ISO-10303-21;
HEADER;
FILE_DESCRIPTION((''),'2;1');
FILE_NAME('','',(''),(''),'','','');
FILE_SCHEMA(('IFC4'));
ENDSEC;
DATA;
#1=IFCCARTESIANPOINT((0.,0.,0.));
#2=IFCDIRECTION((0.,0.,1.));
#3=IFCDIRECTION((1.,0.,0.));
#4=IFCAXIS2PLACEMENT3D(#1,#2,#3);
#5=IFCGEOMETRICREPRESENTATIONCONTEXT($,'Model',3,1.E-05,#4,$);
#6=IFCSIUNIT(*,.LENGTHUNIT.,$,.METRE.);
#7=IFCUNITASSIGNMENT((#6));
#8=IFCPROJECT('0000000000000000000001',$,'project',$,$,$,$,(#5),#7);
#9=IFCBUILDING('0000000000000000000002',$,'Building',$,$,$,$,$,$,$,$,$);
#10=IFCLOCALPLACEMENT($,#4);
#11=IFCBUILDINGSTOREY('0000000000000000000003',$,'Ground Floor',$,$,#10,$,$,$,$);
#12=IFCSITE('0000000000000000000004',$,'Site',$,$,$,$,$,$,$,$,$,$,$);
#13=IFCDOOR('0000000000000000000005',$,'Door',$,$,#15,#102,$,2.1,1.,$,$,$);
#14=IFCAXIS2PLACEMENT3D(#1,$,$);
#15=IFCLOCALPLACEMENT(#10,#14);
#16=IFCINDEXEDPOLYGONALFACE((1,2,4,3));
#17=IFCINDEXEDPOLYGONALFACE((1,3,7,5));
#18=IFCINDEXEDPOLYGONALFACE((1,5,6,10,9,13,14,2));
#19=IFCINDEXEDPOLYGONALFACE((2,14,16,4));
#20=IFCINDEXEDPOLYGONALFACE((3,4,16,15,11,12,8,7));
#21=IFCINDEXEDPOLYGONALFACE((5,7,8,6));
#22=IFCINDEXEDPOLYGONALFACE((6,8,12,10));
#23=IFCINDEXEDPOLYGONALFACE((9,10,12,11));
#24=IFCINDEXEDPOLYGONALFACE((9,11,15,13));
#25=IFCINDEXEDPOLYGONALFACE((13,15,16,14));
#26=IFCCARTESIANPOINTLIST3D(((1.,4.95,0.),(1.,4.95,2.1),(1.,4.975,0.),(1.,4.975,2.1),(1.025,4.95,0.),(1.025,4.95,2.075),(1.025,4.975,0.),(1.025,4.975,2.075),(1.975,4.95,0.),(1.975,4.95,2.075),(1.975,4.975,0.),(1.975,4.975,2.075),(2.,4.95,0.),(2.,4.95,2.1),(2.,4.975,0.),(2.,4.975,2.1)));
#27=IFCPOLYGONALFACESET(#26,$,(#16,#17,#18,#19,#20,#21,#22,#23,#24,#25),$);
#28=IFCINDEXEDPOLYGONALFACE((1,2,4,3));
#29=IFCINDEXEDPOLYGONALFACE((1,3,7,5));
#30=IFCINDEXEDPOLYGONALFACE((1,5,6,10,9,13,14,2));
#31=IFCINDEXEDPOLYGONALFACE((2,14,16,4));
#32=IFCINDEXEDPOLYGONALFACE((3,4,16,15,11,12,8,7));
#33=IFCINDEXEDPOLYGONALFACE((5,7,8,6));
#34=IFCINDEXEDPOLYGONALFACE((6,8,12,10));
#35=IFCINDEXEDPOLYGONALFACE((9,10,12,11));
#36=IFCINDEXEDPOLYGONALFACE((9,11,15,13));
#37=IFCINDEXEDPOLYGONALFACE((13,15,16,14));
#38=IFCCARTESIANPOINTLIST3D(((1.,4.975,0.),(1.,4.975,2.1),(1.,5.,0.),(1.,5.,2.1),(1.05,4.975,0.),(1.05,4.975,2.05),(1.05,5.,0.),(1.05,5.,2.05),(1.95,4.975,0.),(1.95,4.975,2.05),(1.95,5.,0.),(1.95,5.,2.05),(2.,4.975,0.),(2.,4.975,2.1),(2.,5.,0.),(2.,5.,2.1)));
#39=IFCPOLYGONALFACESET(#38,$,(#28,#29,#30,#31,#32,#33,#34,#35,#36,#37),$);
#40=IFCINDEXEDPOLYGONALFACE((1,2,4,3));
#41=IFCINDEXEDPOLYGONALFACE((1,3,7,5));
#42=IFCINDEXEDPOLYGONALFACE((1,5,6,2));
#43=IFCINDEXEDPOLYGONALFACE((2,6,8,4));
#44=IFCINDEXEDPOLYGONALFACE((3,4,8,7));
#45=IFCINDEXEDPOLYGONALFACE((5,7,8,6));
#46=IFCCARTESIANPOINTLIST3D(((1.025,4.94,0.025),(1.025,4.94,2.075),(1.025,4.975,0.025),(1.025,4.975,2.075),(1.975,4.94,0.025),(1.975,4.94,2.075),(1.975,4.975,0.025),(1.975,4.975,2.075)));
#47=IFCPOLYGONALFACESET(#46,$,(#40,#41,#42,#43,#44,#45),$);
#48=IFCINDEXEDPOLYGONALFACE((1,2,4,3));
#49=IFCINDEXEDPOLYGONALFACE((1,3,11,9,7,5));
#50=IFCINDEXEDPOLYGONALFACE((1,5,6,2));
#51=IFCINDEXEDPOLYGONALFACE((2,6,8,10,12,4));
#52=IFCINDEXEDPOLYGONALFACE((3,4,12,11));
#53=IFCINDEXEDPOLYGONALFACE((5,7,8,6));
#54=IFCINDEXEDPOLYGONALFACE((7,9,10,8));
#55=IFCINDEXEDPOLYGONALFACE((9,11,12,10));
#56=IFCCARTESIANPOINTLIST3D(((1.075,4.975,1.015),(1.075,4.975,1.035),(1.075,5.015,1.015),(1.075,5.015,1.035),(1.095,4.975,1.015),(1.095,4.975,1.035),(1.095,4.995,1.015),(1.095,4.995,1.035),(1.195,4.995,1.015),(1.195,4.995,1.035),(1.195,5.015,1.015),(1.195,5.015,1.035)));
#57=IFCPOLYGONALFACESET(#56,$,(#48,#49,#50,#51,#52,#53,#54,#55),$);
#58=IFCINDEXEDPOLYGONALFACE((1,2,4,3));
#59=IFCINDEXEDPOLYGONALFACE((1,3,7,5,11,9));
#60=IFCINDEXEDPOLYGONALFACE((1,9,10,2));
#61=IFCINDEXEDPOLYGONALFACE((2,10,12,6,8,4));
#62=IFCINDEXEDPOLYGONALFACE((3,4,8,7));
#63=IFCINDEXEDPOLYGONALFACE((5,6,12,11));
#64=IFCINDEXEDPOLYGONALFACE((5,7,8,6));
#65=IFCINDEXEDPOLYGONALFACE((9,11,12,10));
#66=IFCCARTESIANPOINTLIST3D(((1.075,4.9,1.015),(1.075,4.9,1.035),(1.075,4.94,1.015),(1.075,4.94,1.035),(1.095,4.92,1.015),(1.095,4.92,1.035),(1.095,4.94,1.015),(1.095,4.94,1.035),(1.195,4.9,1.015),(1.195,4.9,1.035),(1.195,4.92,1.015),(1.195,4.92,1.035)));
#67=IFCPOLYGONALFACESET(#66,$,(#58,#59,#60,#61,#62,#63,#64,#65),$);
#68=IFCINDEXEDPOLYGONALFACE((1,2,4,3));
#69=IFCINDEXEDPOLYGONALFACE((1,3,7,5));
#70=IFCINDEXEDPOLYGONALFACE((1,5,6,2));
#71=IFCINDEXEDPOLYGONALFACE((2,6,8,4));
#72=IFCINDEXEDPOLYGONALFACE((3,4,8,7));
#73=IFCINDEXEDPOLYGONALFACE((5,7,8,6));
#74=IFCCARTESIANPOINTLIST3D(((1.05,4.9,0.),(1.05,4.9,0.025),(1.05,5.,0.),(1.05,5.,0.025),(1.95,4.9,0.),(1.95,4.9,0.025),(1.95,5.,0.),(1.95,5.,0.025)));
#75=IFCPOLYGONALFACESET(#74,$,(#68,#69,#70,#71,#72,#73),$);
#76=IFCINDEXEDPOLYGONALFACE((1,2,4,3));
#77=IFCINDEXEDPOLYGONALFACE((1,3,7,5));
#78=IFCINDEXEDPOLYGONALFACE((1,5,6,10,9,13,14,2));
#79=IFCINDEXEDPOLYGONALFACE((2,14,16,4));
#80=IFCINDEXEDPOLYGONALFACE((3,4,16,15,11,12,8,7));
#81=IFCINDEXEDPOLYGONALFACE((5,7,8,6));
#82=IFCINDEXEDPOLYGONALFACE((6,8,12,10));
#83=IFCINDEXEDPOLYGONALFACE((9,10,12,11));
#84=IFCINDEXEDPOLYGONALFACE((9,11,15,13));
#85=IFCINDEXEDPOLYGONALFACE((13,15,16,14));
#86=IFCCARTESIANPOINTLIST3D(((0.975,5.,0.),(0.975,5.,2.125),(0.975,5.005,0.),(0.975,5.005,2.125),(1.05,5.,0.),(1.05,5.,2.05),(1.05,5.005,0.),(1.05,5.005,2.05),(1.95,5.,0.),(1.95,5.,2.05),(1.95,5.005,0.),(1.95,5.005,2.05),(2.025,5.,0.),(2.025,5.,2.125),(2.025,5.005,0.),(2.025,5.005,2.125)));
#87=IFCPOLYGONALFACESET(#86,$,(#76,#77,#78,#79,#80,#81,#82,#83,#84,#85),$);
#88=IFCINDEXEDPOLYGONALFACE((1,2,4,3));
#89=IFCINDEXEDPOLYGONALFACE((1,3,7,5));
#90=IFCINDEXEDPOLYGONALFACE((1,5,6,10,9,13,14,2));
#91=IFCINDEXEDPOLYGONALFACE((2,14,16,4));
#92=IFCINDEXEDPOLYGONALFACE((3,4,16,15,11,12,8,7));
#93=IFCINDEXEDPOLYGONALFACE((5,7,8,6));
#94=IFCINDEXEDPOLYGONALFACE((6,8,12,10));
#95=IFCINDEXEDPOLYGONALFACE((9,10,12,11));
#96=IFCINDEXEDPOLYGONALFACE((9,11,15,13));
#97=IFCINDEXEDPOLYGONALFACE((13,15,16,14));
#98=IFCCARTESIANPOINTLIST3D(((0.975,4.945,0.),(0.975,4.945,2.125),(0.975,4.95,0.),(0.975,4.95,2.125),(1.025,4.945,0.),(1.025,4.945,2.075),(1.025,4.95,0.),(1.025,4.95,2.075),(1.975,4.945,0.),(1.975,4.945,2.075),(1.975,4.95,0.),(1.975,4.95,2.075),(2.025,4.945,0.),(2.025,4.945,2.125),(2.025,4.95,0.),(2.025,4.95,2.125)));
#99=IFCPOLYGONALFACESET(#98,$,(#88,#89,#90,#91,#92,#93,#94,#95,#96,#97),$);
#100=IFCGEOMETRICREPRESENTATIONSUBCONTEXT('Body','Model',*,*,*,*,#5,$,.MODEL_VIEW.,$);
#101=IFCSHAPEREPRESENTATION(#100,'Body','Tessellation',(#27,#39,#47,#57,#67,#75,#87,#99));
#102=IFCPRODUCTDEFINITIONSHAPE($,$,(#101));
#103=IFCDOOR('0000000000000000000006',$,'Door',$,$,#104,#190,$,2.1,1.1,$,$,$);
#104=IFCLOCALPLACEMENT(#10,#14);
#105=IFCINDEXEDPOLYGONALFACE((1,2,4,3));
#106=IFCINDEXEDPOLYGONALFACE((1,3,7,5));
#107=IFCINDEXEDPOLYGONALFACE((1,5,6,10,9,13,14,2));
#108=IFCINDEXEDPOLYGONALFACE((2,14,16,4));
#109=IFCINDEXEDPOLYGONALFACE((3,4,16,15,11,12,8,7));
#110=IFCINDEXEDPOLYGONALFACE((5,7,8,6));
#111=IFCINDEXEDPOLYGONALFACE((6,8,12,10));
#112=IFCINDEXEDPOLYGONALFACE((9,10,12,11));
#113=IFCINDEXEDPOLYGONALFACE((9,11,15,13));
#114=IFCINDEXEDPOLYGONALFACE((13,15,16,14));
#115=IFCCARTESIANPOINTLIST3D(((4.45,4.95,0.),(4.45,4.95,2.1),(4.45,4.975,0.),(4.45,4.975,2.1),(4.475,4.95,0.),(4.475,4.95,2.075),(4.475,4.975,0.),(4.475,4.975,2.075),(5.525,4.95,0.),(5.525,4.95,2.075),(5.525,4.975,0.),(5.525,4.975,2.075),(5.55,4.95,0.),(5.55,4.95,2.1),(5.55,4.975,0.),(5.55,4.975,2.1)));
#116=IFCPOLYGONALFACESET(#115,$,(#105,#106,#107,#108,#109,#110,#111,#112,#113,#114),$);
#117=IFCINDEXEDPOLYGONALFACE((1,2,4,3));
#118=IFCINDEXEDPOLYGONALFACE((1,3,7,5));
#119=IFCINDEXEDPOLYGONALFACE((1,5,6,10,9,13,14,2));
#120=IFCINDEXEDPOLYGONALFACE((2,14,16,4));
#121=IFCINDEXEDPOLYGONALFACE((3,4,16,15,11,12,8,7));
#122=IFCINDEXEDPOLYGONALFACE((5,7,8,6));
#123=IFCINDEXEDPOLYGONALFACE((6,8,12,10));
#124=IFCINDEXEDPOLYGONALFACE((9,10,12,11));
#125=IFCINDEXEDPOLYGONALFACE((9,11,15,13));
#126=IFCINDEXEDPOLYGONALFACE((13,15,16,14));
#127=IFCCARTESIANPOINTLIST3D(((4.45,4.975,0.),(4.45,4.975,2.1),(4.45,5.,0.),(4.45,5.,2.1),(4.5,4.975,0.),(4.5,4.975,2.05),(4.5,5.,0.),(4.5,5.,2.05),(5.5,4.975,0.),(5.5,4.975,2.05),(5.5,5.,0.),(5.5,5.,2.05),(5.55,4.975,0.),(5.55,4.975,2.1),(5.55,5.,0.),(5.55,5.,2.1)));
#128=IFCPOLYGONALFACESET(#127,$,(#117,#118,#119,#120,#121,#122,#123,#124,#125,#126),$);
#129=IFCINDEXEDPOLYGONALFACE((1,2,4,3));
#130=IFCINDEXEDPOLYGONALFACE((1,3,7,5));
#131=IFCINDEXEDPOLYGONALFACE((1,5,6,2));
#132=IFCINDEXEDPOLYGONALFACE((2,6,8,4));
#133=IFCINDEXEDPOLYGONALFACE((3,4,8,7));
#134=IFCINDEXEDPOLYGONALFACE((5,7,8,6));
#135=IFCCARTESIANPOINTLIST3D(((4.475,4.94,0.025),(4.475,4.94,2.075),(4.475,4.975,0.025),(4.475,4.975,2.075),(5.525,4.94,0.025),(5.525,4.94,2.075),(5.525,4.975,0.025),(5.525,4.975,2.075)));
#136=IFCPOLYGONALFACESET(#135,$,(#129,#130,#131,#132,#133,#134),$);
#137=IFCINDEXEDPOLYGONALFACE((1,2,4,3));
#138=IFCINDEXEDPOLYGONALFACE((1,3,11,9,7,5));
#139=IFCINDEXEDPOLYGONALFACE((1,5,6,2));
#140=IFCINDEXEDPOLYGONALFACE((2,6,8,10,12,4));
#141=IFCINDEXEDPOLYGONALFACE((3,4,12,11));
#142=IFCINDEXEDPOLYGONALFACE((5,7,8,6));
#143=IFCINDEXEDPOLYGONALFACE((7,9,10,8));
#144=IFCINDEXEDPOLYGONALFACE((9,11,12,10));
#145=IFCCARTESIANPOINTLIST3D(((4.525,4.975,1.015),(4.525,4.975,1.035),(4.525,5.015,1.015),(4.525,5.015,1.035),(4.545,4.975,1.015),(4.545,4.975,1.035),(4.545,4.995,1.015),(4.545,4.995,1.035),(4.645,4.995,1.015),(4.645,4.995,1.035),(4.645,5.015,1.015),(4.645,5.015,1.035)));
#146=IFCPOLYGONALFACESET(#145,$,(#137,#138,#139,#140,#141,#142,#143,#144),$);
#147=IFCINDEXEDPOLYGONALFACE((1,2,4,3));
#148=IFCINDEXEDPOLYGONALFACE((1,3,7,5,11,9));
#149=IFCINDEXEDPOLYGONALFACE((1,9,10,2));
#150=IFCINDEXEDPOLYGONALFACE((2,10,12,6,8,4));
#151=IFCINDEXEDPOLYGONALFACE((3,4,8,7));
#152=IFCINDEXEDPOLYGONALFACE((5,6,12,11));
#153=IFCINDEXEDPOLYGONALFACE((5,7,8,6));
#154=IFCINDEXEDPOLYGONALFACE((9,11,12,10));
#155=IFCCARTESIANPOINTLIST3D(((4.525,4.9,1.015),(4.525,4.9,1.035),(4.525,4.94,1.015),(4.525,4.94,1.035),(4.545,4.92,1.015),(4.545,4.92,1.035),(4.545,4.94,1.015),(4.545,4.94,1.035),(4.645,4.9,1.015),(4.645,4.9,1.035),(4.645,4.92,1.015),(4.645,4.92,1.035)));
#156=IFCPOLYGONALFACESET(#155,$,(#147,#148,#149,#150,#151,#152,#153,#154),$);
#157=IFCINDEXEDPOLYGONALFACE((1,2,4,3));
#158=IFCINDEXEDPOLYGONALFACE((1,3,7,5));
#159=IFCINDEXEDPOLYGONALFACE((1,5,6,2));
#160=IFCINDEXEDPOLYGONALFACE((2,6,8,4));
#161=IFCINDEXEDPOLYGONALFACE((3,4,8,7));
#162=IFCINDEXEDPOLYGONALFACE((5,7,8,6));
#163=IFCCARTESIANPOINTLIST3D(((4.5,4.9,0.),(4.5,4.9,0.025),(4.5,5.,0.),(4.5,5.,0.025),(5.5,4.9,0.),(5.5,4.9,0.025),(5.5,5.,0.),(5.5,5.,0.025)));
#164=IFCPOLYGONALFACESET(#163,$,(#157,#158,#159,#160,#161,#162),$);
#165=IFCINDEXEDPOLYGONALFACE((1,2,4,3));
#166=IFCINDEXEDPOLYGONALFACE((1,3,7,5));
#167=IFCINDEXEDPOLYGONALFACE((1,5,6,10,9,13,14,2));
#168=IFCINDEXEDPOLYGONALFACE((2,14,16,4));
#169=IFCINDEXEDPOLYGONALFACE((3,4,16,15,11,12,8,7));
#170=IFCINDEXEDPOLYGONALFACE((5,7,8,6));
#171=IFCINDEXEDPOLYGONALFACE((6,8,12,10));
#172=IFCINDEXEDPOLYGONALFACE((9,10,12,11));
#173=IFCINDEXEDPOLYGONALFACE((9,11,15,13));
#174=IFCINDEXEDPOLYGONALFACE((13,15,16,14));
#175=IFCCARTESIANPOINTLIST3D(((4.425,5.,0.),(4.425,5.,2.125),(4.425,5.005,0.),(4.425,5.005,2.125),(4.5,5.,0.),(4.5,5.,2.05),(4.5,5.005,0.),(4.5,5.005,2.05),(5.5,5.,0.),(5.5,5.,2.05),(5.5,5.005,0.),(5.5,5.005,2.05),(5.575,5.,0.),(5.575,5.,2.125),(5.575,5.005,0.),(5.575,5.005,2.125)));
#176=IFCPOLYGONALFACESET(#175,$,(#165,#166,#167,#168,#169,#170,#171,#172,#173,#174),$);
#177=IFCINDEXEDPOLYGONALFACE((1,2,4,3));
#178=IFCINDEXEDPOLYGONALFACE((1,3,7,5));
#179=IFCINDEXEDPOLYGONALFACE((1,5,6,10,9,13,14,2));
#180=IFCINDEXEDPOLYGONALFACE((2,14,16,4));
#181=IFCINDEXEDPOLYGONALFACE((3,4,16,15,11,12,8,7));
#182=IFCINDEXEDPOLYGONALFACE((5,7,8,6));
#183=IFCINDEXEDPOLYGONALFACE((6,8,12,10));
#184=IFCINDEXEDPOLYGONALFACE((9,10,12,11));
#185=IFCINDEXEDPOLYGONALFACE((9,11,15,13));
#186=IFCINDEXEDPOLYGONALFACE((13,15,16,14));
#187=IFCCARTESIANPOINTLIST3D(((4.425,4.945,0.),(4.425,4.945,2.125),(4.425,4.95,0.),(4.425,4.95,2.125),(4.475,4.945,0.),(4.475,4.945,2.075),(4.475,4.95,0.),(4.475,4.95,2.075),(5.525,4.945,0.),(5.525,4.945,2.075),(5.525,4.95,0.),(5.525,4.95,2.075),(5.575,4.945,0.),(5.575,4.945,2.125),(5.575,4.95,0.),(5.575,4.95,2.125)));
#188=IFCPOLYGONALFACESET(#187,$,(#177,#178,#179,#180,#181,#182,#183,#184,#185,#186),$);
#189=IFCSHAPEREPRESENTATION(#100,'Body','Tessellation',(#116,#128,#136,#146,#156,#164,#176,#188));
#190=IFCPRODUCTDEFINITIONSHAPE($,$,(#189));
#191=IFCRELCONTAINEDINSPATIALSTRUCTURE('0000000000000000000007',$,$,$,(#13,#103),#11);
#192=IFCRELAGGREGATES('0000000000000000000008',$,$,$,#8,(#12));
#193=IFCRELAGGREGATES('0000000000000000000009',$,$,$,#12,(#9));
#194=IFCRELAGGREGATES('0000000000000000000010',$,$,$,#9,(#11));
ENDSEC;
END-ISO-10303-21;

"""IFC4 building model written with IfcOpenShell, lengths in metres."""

from ifc_helpers import new_model, si_unit, frame, origin_with_axes, place, context, subcontext, project, spatial, line, indexed_curve, outline, extrude, element, save


model = new_model("IFC4")

# Units and contexts
model_context = context("Model", 3, precision=1e-05, world=origin_with_axes())
body_context = subcontext(model_context, "Body", "Model", "MODEL_VIEW")
ifc_project = project(units=[si_unit("LENGTHUNIT", "METRE")], contexts=[model_context])

# Site, building, storey
site = spatial("IfcSite", under=ifc_project, Name="Site")
building = spatial("IfcBuilding", under=site, Name="Building")
storey_placement = place(None, origin_with_axes())
storey = spatial("IfcBuildingStorey", under=building, at=storey_placement, Name="Ground Floor")

# Doors
door_1_placement = place(storey_placement, frame((2.0, 5.0, 0.0), z_axis=(0.0, 0.0, 1.0), x_axis=(-1.0, 0.0, 0.0)))
element("IfcDoor", 1, at=door_1_placement, inside=storey, Name="Door", OverallHeight=2.1, OverallWidth=1.0, context=body_context, shape_type="SweptSolid", body=[
    extrude(outline(indexed_curve([(0.0, 0.0), (0.0, 2.1), (1.0, 2.1), (1.0, 0.0), (0.975, 0.0), (0.975, 2.075), (0.025, 2.075), (0.025, 0.0)], segments=[line(1, 2, 3, 4, 5, 6, 7, 8, 1)])), frame((0.0, 0.025, 0.0), z_axis=(0.0, -1.0, 0.0), x_axis=(1.0, 0.0, 0.0)), (0.0, 0.0, -1.0), 0.025),
    extrude(outline(indexed_curve([(0.0, 0.0), (0.0, 2.1), (1.0, 2.1), (1.0, 0.0), (0.95, 0.0), (0.95, 2.05), (0.05, 2.05), (0.05, 0.0)], segments=[line(1, 2, 3, 4, 5, 6, 7, 8, 1)])), frame((0.0, 0.0, 0.0), z_axis=(0.0, -1.0, 0.0), x_axis=(1.0, 0.0, 0.0)), (0.0, 0.0, -1.0), 0.025),
    extrude(outline(indexed_curve([(0.0, 0.0), (0.95, 0.0), (0.95, 0.035), (0.0, 0.035)], segments=[line(1, 2, 3, 4, 1)])), frame((0.025, 0.025, 0.025), z_axis=(0.0, 0.0, 1.0), x_axis=(1.0, 0.0, 0.0)), (0.0, 0.0, 1.0), 2.05),
    extrude(outline(indexed_curve([(0.0, 0.0), (0.0, -0.04), (-0.12, -0.04), (-0.12, -0.02), (-0.02, -0.02), (-0.02, 0.0)], segments=[line(1, 2, 3, 4, 5, 6, 1)])), frame((0.925, 0.025, 1.015), z_axis=(0.0, 0.0, 1.0), x_axis=(1.0, 0.0, 0.0)), (0.0, 0.0, 1.0), 0.02),
    extrude(outline(indexed_curve([(0.0, 0.0), (0.0, 0.04), (-0.12, 0.04), (-0.12, 0.02), (-0.02, 0.02), (-0.02, 0.0)], segments=[line(1, 2, 3, 4, 5, 6, 1)])), frame((0.925, 0.06, 1.015), z_axis=(0.0, 0.0, 1.0), x_axis=(1.0, 0.0, 0.0)), (0.0, 0.0, 1.0), 0.02),
    extrude(outline(indexed_curve([(0.0, 0.0), (0.9, 0.0), (0.9, 0.1), (0.0, 0.1)], segments=[line(1, 2, 3, 4, 1)])), frame((0.05, 0.0, 0.0), z_axis=(0.0, 0.0, 1.0), x_axis=(1.0, 0.0, 0.0)), (0.0, 0.0, 1.0), 0.025),
    extrude(outline(indexed_curve([(0.0, 0.0), (0.0, 2.125), (1.05, 2.125), (1.05, 0.0), (0.975, 0.0), (0.975, 2.05), (0.075, 2.05), (0.075, 0.0)], segments=[line(1, 2, 3, 4, 5, 6, 7, 8, 1)])), frame((-0.025, -0.005, 0.0), z_axis=(0.0, -1.0, 0.0), x_axis=(1.0, 0.0, 0.0)), (0.0, 0.0, -1.0), 0.005),
    extrude(outline(indexed_curve([(0.0, 0.0), (0.0, 2.125), (1.05, 2.125), (1.05, 0.0), (1.0, 0.0), (1.0, 2.075), (0.05, 2.075), (0.05, 0.0)], segments=[line(1, 2, 3, 4, 5, 6, 7, 8, 1)])), frame((-0.025, 0.05, 0.0), z_axis=(0.0, -1.0, 0.0), x_axis=(1.0, 0.0, 0.0)), (0.0, 0.0, -1.0), 0.005),
])
door_2_placement = place(storey_placement, frame((5.55, 5.0, 0.0), z_axis=(0.0, 0.0, 1.0), x_axis=(-1.0, 0.0, 0.0)))
element("IfcDoor", 2, at=door_2_placement, inside=storey, Name="Door", OverallHeight=2.1, OverallWidth=1.1, context=body_context, shape_type="SweptSolid", body=[
    extrude(outline(indexed_curve([(0.0, 0.0), (0.0, 2.1), (1.1, 2.1), (1.1, 0.0), (1.075, 0.0), (1.075, 2.075), (0.025, 2.075), (0.025, 0.0)], segments=[line(1, 2, 3, 4, 5, 6, 7, 8, 1)])), frame((0.0, 0.025, 0.0), z_axis=(0.0, -1.0, 0.0), x_axis=(1.0, 0.0, 0.0)), (0.0, 0.0, -1.0), 0.025),
    extrude(outline(indexed_curve([(0.0, 0.0), (0.0, 2.1), (1.1, 2.1), (1.1, 0.0), (1.05, 0.0), (1.05, 2.05), (0.05, 2.05), (0.05, 0.0)], segments=[line(1, 2, 3, 4, 5, 6, 7, 8, 1)])), frame((0.0, 0.0, 0.0), z_axis=(0.0, -1.0, 0.0), x_axis=(1.0, 0.0, 0.0)), (0.0, 0.0, -1.0), 0.025),
    extrude(outline(indexed_curve([(0.0, 0.0), (1.05, 0.0), (1.05, 0.035), (0.0, 0.035)], segments=[line(1, 2, 3, 4, 1)])), frame((0.025, 0.025, 0.025), z_axis=(0.0, 0.0, 1.0), x_axis=(1.0, 0.0, 0.0)), (0.0, 0.0, 1.0), 2.05),
    extrude(outline(indexed_curve([(0.0, 0.0), (0.0, -0.04), (-0.12, -0.04), (-0.12, -0.02), (-0.02, -0.02), (-0.02, 0.0)], segments=[line(1, 2, 3, 4, 5, 6, 1)])), frame((1.025, 0.025, 1.015), z_axis=(0.0, 0.0, 1.0), x_axis=(1.0, 0.0, 0.0)), (0.0, 0.0, 1.0), 0.02),
    extrude(outline(indexed_curve([(0.0, 0.0), (0.0, 0.04), (-0.12, 0.04), (-0.12, 0.02), (-0.02, 0.02), (-0.02, 0.0)], segments=[line(1, 2, 3, 4, 5, 6, 1)])), frame((1.025, 0.06, 1.015), z_axis=(0.0, 0.0, 1.0), x_axis=(1.0, 0.0, 0.0)), (0.0, 0.0, 1.0), 0.02),
    extrude(outline(indexed_curve([(0.0, 0.0), (1.0, 0.0), (1.0, 0.1), (0.0, 0.1)], segments=[line(1, 2, 3, 4, 1)])), frame((0.05, 0.0, 0.0), z_axis=(0.0, 0.0, 1.0), x_axis=(1.0, 0.0, 0.0)), (0.0, 0.0, 1.0), 0.025),
    extrude(outline(indexed_curve([(0.0, 0.0), (0.0, 2.125), (1.15, 2.125), (1.15, 0.0), (1.075, 0.0), (1.075, 2.05), (0.075, 2.05), (0.075, 0.0)], segments=[line(1, 2, 3, 4, 5, 6, 7, 8, 1)])), frame((-0.025, -0.005, 0.0), z_axis=(0.0, -1.0, 0.0), x_axis=(1.0, 0.0, 0.0)), (0.0, 0.0, -1.0), 0.005),
    extrude(outline(indexed_curve([(0.0, 0.0), (0.0, 2.125), (1.15, 2.125), (1.15, 0.0), (1.1, 0.0), (1.1, 2.075), (0.05, 2.075), (0.05, 0.0)], segments=[line(1, 2, 3, 4, 5, 6, 7, 8, 1)])), frame((-0.025, 0.05, 0.0), z_axis=(0.0, -1.0, 0.0), x_axis=(1.0, 0.0, 0.0)), (0.0, 0.0, -1.0), 0.005),
])

save(model, "model.ifc")
